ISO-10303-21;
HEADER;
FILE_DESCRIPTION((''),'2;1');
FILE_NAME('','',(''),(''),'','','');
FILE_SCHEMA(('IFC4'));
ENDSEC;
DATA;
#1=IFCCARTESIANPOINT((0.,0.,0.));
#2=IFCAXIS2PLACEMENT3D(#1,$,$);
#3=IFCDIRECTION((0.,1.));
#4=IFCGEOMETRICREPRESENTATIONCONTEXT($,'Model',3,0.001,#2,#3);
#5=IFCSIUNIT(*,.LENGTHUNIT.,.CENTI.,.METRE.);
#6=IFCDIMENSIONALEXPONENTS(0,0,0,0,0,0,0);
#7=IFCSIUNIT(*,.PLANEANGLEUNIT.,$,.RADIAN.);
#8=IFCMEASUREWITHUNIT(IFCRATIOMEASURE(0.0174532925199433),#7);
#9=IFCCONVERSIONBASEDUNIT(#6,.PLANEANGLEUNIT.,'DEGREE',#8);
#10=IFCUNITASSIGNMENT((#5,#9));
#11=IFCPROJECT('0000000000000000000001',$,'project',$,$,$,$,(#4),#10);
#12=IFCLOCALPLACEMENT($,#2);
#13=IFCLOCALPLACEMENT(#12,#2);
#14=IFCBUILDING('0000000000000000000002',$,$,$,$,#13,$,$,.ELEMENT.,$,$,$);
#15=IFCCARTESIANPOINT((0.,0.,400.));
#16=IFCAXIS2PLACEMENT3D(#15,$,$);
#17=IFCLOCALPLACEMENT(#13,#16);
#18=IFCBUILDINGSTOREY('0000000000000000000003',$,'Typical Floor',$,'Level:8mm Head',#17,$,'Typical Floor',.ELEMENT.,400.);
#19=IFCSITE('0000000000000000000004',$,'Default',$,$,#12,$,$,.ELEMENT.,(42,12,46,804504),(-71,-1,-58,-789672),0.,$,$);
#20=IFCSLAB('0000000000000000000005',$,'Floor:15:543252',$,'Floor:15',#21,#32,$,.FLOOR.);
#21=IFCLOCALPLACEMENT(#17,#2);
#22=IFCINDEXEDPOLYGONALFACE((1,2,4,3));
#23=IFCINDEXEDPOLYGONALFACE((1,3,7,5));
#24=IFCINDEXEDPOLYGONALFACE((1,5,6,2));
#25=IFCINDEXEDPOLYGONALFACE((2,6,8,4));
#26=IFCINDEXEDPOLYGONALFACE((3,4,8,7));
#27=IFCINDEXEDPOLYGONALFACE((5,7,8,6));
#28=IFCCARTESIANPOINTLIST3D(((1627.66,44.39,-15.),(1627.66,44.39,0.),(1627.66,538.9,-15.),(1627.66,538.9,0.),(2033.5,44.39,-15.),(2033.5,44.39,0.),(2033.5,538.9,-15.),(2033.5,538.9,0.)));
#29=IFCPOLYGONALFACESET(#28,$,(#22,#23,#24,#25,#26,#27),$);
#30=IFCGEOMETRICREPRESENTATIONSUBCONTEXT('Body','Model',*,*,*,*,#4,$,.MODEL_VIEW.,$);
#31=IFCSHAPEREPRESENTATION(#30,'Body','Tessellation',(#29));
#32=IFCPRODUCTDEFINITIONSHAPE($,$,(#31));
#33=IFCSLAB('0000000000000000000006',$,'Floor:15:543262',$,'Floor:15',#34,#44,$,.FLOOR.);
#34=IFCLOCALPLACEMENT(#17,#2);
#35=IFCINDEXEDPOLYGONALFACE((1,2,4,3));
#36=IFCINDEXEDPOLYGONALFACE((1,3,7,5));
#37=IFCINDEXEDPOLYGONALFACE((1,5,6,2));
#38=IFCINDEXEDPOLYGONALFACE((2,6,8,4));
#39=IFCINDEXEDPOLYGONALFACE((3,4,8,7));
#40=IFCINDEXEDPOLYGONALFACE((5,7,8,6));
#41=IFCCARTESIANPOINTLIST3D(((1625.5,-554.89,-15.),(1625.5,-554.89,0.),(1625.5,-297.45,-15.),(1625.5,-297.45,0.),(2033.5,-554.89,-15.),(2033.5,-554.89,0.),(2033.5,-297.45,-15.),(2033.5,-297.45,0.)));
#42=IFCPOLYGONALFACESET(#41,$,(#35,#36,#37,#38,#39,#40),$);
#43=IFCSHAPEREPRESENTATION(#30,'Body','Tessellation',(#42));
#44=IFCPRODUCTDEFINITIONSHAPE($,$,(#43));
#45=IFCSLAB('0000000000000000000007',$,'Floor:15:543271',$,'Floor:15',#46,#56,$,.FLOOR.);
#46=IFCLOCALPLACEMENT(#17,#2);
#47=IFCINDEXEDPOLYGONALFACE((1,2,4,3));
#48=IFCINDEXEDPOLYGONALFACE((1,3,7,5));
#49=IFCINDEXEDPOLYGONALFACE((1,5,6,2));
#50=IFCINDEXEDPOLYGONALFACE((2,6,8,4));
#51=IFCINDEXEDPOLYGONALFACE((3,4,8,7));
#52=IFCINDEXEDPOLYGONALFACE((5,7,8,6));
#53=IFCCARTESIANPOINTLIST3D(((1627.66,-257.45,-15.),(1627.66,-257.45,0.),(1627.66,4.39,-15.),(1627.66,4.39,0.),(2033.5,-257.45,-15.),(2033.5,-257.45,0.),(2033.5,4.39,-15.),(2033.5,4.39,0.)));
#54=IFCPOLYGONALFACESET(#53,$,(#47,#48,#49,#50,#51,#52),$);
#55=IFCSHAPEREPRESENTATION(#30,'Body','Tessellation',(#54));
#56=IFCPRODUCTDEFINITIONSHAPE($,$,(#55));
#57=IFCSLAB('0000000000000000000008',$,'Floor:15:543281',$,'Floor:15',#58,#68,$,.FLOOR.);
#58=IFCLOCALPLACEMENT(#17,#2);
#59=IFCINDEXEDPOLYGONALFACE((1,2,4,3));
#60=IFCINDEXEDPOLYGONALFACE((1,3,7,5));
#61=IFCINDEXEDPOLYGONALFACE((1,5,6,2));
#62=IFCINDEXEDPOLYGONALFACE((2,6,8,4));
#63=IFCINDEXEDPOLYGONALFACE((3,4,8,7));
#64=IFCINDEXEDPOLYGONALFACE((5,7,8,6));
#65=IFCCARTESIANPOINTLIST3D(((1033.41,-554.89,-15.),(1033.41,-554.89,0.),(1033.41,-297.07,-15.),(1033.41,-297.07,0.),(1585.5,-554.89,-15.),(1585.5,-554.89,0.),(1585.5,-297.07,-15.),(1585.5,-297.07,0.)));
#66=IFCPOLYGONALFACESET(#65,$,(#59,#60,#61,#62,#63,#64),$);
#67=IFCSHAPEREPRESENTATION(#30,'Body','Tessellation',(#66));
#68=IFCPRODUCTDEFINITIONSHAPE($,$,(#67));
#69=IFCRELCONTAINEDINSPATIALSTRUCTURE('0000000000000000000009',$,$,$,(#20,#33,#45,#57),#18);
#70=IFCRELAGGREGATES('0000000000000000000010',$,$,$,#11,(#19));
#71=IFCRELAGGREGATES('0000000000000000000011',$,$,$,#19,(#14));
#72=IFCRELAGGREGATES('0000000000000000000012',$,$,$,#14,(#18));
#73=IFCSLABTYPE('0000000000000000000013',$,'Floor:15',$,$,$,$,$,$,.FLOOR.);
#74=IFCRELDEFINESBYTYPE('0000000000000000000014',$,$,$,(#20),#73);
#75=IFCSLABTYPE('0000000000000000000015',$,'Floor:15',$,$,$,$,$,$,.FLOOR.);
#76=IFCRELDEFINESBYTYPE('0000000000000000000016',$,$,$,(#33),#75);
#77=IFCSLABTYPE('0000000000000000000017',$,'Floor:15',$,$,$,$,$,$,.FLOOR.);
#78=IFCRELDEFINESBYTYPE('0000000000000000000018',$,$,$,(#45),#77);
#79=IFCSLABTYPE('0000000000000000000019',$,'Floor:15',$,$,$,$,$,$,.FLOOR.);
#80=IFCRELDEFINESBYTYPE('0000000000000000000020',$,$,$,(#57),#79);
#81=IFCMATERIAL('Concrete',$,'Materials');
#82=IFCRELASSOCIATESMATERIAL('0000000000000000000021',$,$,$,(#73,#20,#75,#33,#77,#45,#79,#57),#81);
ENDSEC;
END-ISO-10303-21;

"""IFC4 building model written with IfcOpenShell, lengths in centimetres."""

from ifc_helpers import new_model, entity, si_unit, converted_unit, direction, frame, origin, place, context, subcontext, project, spatial, indexed_curve, outline, extrude, material, type_object, element, save


model = new_model("IFC4")

# Units and contexts
model_context = context("Model", 3, precision=0.001, world=origin(), true_north=direction((0.0, 1.0)))
body_context = subcontext(model_context, "Body", "Model", "MODEL_VIEW")
ifc_project = project(units=[si_unit("LENGTHUNIT", "METRE", prefix="CENTI"), converted_unit("PLANEANGLEUNIT", "DEGREE", entity("IfcRatioMeasure", 0.0174532925199433), si_unit("PLANEANGLEUNIT", "RADIAN"), dimensions=[0, 0, 0, 0, 0, 0, 0])], contexts=[model_context])

# Site, building, storey
site_placement = place(None, origin())
site = spatial("IfcSite", under=ifc_project, at=site_placement, Name="Default", CompositionType="ELEMENT", RefLatitude=(42, 12, 46, 804504), RefLongitude=(-71, -1, -58, -789672), RefElevation=0.0)
building_placement = place(site_placement, origin())
building = spatial("IfcBuilding", under=site, at=building_placement, CompositionType="ELEMENT")
storey_placement = place(building_placement, frame((0.0, 0.0, 400.0)))
storey = spatial("IfcBuildingStorey", under=building, at=storey_placement, Name="Typical Floor", ObjectType="Level:8mm Head", LongName="Typical Floor", CompositionType="ELEMENT", Elevation=400.0)

# Shared definitions
ifc_material = material(Name="Concrete", Category="Materials")

# Slabs
slab_type_1 = type_object("IfcSlabType", Name="Floor:15", PredefinedType="FLOOR", material=ifc_material)
slab_1_placement = place(storey_placement, origin())
element("IfcSlab", 1, at=slab_1_placement, inside=storey, type_object=slab_type_1, material=ifc_material, Name="Floor:15:543252", ObjectType="Floor:15", PredefinedType="FLOOR", context=body_context, shape_type="SweptSolid", body=[
    extrude(outline(indexed_curve([(-247.25, -202.92), (247.25, -202.92), (247.25, 202.92), (-247.25, 202.92), (-247.25, -202.92)], self_intersect=False)), frame((1830.58, 291.65, 0.0), z_axis=(0.0, 0.0, -1.0), x_axis=(0.0, 1.0, 0.0)), (0.0, 0.0, 1.0), 15.0),
])
slab_type_2 = type_object("IfcSlabType", Name="Floor:15", PredefinedType="FLOOR", material=ifc_material)
slab_2_placement = place(storey_placement, origin())
element("IfcSlab", 2, at=slab_2_placement, inside=storey, type_object=slab_type_2, material=ifc_material, Name="Floor:15:543262", ObjectType="Floor:15", PredefinedType="FLOOR", context=body_context, shape_type="SweptSolid", body=[
    extrude(outline(indexed_curve([(-128.72, -204.0), (128.72, -204.0), (128.72, 204.0), (-128.72, 204.0), (-128.72, -204.0)], self_intersect=False)), frame((1829.5, -426.17, 0.0), z_axis=(0.0, 0.0, -1.0), x_axis=(0.0, 1.0, 0.0)), (0.0, 0.0, 1.0), 15.0),
])
slab_type_3 = type_object("IfcSlabType", Name="Floor:15", PredefinedType="FLOOR", material=ifc_material)
slab_3_placement = place(storey_placement, origin())
element("IfcSlab", 3, at=slab_3_placement, inside=storey, type_object=slab_type_3, material=ifc_material, Name="Floor:15:543271", ObjectType="Floor:15", PredefinedType="FLOOR", context=body_context, shape_type="SweptSolid", body=[
    extrude(outline(indexed_curve([(-130.92, -202.92), (130.92, -202.92), (130.92, 202.92), (-130.92, 202.92), (-130.92, -202.92)], self_intersect=False)), frame((1830.58, -126.53, 0.0), z_axis=(0.0, 0.0, -1.0), x_axis=(0.0, 1.0, 0.0)), (0.0, 0.0, 1.0), 15.0),
])
slab_type_4 = type_object("IfcSlabType", Name="Floor:15", PredefinedType="FLOOR", material=ifc_material)
slab_4_placement = place(storey_placement, origin())
element("IfcSlab", 4, at=slab_4_placement, inside=storey, type_object=slab_type_4, material=ifc_material, Name="Floor:15:543281", ObjectType="Floor:15", PredefinedType="FLOOR", context=body_context, shape_type="SweptSolid", body=[
    extrude(outline(indexed_curve([(-128.91, -276.05), (128.91, -276.05), (128.91, 276.05), (-128.91, 276.05), (-128.91, -276.05)], self_intersect=False)), frame((1309.46, -425.98, 0.0), z_axis=(0.0, 0.0, -1.0), x_axis=(0.0, 1.0, 0.0)), (0.0, 0.0, 1.0), 15.0),
])

save(model, "model.ifc")
